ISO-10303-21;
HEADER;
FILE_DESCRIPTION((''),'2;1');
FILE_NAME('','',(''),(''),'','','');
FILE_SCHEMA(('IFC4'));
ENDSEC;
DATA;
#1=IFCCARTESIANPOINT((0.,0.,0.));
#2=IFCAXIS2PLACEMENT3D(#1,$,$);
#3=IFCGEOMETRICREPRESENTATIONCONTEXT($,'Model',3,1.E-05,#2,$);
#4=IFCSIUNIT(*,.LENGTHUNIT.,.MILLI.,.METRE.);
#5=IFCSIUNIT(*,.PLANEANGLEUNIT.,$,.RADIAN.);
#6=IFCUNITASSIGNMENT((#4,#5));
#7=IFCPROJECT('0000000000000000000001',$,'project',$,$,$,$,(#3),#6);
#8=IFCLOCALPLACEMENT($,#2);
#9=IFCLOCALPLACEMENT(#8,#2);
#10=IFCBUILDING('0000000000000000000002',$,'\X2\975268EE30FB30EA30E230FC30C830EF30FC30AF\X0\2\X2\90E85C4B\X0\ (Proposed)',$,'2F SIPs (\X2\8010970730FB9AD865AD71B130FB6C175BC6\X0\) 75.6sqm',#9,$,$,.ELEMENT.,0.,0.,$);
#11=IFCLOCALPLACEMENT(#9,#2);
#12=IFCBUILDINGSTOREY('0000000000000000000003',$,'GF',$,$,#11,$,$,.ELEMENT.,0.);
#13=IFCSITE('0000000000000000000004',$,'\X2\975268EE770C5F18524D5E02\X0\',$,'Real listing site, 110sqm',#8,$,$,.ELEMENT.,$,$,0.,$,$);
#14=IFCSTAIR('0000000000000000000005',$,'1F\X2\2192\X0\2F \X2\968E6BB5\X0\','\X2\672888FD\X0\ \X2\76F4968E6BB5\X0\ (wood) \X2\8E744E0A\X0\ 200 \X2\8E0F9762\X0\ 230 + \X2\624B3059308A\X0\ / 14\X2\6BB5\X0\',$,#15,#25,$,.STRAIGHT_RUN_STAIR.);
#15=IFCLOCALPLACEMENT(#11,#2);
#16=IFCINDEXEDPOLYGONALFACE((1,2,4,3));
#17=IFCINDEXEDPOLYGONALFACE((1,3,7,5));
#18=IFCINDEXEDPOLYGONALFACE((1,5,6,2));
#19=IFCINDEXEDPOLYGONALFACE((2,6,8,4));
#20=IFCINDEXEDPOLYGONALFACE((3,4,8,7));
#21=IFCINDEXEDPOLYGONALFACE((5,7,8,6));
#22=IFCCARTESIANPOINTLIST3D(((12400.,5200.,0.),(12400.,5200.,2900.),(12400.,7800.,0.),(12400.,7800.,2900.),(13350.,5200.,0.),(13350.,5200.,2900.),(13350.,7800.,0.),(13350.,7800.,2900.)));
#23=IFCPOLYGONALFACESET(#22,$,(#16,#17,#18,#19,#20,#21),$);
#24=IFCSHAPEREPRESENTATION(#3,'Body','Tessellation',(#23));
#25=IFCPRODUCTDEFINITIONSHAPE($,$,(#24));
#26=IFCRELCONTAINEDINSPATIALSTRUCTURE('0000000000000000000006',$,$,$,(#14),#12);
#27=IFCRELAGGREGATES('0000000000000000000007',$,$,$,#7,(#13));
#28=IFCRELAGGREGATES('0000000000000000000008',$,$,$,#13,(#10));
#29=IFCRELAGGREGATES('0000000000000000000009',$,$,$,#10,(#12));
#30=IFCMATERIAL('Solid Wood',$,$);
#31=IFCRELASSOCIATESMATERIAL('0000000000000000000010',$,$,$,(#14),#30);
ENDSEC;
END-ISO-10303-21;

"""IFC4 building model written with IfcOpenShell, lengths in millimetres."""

from ifc_helpers import new_model, si_unit, frame, frame_2d, origin, place, context, project, spatial, rectangle, extrude, material, element, save


model = new_model("IFC4")

# Units and contexts
model_context = context("Model", 3, precision=1e-05, world=origin())
ifc_project = project(units=[si_unit("LENGTHUNIT", "METRE", prefix="MILLI"), si_unit("PLANEANGLEUNIT", "RADIAN")], contexts=[model_context])

# Site, building, storey
site_placement = place(None, origin())
site = spatial("IfcSite", under=ifc_project, at=site_placement, Name="青森県弘前市", ObjectType="Real listing site, 110sqm", CompositionType="ELEMENT", RefElevation=0.0)
building_placement = place(site_placement, origin())
building = spatial("IfcBuilding", under=site, at=building_placement, Name="青森・リモートワーク2部屋 (Proposed)", ObjectType="2F SIPs (耐震・高断熱・気密) 75.6sqm", CompositionType="ELEMENT", ElevationOfRefHeight=0.0, ElevationOfTerrain=0.0)
storey_placement = place(building_placement, origin())
storey = spatial("IfcBuildingStorey", under=building, at=storey_placement, Name="GF", CompositionType="ELEMENT", Elevation=0.0)

# Shared definitions
ifc_material_1 = material(Name="Solid Wood")

# Stair
stair_1_placement = place(storey_placement, frame((6200.0, 2600.0, 0.0)))
element("IfcStair", 1, at=stair_1_placement, inside=storey, material=ifc_material_1, Name="1F→2F 階段", Description="木製 直階段 (wood) 蹴上 200 踏面 230 + 手すり / 14段", PredefinedType="STRAIGHT_RUN_STAIR", context=model_context, shape_type="SweptSolid", body=[
    extrude(rectangle(XDim=950.0, YDim=2600.0, at=frame_2d((475.0, 1300.0))), frame((6200.0, 2600.0, 0.0)), (0.0, 0.0, 1.0), 2900.0),
])

save(model, "model.ifc")
